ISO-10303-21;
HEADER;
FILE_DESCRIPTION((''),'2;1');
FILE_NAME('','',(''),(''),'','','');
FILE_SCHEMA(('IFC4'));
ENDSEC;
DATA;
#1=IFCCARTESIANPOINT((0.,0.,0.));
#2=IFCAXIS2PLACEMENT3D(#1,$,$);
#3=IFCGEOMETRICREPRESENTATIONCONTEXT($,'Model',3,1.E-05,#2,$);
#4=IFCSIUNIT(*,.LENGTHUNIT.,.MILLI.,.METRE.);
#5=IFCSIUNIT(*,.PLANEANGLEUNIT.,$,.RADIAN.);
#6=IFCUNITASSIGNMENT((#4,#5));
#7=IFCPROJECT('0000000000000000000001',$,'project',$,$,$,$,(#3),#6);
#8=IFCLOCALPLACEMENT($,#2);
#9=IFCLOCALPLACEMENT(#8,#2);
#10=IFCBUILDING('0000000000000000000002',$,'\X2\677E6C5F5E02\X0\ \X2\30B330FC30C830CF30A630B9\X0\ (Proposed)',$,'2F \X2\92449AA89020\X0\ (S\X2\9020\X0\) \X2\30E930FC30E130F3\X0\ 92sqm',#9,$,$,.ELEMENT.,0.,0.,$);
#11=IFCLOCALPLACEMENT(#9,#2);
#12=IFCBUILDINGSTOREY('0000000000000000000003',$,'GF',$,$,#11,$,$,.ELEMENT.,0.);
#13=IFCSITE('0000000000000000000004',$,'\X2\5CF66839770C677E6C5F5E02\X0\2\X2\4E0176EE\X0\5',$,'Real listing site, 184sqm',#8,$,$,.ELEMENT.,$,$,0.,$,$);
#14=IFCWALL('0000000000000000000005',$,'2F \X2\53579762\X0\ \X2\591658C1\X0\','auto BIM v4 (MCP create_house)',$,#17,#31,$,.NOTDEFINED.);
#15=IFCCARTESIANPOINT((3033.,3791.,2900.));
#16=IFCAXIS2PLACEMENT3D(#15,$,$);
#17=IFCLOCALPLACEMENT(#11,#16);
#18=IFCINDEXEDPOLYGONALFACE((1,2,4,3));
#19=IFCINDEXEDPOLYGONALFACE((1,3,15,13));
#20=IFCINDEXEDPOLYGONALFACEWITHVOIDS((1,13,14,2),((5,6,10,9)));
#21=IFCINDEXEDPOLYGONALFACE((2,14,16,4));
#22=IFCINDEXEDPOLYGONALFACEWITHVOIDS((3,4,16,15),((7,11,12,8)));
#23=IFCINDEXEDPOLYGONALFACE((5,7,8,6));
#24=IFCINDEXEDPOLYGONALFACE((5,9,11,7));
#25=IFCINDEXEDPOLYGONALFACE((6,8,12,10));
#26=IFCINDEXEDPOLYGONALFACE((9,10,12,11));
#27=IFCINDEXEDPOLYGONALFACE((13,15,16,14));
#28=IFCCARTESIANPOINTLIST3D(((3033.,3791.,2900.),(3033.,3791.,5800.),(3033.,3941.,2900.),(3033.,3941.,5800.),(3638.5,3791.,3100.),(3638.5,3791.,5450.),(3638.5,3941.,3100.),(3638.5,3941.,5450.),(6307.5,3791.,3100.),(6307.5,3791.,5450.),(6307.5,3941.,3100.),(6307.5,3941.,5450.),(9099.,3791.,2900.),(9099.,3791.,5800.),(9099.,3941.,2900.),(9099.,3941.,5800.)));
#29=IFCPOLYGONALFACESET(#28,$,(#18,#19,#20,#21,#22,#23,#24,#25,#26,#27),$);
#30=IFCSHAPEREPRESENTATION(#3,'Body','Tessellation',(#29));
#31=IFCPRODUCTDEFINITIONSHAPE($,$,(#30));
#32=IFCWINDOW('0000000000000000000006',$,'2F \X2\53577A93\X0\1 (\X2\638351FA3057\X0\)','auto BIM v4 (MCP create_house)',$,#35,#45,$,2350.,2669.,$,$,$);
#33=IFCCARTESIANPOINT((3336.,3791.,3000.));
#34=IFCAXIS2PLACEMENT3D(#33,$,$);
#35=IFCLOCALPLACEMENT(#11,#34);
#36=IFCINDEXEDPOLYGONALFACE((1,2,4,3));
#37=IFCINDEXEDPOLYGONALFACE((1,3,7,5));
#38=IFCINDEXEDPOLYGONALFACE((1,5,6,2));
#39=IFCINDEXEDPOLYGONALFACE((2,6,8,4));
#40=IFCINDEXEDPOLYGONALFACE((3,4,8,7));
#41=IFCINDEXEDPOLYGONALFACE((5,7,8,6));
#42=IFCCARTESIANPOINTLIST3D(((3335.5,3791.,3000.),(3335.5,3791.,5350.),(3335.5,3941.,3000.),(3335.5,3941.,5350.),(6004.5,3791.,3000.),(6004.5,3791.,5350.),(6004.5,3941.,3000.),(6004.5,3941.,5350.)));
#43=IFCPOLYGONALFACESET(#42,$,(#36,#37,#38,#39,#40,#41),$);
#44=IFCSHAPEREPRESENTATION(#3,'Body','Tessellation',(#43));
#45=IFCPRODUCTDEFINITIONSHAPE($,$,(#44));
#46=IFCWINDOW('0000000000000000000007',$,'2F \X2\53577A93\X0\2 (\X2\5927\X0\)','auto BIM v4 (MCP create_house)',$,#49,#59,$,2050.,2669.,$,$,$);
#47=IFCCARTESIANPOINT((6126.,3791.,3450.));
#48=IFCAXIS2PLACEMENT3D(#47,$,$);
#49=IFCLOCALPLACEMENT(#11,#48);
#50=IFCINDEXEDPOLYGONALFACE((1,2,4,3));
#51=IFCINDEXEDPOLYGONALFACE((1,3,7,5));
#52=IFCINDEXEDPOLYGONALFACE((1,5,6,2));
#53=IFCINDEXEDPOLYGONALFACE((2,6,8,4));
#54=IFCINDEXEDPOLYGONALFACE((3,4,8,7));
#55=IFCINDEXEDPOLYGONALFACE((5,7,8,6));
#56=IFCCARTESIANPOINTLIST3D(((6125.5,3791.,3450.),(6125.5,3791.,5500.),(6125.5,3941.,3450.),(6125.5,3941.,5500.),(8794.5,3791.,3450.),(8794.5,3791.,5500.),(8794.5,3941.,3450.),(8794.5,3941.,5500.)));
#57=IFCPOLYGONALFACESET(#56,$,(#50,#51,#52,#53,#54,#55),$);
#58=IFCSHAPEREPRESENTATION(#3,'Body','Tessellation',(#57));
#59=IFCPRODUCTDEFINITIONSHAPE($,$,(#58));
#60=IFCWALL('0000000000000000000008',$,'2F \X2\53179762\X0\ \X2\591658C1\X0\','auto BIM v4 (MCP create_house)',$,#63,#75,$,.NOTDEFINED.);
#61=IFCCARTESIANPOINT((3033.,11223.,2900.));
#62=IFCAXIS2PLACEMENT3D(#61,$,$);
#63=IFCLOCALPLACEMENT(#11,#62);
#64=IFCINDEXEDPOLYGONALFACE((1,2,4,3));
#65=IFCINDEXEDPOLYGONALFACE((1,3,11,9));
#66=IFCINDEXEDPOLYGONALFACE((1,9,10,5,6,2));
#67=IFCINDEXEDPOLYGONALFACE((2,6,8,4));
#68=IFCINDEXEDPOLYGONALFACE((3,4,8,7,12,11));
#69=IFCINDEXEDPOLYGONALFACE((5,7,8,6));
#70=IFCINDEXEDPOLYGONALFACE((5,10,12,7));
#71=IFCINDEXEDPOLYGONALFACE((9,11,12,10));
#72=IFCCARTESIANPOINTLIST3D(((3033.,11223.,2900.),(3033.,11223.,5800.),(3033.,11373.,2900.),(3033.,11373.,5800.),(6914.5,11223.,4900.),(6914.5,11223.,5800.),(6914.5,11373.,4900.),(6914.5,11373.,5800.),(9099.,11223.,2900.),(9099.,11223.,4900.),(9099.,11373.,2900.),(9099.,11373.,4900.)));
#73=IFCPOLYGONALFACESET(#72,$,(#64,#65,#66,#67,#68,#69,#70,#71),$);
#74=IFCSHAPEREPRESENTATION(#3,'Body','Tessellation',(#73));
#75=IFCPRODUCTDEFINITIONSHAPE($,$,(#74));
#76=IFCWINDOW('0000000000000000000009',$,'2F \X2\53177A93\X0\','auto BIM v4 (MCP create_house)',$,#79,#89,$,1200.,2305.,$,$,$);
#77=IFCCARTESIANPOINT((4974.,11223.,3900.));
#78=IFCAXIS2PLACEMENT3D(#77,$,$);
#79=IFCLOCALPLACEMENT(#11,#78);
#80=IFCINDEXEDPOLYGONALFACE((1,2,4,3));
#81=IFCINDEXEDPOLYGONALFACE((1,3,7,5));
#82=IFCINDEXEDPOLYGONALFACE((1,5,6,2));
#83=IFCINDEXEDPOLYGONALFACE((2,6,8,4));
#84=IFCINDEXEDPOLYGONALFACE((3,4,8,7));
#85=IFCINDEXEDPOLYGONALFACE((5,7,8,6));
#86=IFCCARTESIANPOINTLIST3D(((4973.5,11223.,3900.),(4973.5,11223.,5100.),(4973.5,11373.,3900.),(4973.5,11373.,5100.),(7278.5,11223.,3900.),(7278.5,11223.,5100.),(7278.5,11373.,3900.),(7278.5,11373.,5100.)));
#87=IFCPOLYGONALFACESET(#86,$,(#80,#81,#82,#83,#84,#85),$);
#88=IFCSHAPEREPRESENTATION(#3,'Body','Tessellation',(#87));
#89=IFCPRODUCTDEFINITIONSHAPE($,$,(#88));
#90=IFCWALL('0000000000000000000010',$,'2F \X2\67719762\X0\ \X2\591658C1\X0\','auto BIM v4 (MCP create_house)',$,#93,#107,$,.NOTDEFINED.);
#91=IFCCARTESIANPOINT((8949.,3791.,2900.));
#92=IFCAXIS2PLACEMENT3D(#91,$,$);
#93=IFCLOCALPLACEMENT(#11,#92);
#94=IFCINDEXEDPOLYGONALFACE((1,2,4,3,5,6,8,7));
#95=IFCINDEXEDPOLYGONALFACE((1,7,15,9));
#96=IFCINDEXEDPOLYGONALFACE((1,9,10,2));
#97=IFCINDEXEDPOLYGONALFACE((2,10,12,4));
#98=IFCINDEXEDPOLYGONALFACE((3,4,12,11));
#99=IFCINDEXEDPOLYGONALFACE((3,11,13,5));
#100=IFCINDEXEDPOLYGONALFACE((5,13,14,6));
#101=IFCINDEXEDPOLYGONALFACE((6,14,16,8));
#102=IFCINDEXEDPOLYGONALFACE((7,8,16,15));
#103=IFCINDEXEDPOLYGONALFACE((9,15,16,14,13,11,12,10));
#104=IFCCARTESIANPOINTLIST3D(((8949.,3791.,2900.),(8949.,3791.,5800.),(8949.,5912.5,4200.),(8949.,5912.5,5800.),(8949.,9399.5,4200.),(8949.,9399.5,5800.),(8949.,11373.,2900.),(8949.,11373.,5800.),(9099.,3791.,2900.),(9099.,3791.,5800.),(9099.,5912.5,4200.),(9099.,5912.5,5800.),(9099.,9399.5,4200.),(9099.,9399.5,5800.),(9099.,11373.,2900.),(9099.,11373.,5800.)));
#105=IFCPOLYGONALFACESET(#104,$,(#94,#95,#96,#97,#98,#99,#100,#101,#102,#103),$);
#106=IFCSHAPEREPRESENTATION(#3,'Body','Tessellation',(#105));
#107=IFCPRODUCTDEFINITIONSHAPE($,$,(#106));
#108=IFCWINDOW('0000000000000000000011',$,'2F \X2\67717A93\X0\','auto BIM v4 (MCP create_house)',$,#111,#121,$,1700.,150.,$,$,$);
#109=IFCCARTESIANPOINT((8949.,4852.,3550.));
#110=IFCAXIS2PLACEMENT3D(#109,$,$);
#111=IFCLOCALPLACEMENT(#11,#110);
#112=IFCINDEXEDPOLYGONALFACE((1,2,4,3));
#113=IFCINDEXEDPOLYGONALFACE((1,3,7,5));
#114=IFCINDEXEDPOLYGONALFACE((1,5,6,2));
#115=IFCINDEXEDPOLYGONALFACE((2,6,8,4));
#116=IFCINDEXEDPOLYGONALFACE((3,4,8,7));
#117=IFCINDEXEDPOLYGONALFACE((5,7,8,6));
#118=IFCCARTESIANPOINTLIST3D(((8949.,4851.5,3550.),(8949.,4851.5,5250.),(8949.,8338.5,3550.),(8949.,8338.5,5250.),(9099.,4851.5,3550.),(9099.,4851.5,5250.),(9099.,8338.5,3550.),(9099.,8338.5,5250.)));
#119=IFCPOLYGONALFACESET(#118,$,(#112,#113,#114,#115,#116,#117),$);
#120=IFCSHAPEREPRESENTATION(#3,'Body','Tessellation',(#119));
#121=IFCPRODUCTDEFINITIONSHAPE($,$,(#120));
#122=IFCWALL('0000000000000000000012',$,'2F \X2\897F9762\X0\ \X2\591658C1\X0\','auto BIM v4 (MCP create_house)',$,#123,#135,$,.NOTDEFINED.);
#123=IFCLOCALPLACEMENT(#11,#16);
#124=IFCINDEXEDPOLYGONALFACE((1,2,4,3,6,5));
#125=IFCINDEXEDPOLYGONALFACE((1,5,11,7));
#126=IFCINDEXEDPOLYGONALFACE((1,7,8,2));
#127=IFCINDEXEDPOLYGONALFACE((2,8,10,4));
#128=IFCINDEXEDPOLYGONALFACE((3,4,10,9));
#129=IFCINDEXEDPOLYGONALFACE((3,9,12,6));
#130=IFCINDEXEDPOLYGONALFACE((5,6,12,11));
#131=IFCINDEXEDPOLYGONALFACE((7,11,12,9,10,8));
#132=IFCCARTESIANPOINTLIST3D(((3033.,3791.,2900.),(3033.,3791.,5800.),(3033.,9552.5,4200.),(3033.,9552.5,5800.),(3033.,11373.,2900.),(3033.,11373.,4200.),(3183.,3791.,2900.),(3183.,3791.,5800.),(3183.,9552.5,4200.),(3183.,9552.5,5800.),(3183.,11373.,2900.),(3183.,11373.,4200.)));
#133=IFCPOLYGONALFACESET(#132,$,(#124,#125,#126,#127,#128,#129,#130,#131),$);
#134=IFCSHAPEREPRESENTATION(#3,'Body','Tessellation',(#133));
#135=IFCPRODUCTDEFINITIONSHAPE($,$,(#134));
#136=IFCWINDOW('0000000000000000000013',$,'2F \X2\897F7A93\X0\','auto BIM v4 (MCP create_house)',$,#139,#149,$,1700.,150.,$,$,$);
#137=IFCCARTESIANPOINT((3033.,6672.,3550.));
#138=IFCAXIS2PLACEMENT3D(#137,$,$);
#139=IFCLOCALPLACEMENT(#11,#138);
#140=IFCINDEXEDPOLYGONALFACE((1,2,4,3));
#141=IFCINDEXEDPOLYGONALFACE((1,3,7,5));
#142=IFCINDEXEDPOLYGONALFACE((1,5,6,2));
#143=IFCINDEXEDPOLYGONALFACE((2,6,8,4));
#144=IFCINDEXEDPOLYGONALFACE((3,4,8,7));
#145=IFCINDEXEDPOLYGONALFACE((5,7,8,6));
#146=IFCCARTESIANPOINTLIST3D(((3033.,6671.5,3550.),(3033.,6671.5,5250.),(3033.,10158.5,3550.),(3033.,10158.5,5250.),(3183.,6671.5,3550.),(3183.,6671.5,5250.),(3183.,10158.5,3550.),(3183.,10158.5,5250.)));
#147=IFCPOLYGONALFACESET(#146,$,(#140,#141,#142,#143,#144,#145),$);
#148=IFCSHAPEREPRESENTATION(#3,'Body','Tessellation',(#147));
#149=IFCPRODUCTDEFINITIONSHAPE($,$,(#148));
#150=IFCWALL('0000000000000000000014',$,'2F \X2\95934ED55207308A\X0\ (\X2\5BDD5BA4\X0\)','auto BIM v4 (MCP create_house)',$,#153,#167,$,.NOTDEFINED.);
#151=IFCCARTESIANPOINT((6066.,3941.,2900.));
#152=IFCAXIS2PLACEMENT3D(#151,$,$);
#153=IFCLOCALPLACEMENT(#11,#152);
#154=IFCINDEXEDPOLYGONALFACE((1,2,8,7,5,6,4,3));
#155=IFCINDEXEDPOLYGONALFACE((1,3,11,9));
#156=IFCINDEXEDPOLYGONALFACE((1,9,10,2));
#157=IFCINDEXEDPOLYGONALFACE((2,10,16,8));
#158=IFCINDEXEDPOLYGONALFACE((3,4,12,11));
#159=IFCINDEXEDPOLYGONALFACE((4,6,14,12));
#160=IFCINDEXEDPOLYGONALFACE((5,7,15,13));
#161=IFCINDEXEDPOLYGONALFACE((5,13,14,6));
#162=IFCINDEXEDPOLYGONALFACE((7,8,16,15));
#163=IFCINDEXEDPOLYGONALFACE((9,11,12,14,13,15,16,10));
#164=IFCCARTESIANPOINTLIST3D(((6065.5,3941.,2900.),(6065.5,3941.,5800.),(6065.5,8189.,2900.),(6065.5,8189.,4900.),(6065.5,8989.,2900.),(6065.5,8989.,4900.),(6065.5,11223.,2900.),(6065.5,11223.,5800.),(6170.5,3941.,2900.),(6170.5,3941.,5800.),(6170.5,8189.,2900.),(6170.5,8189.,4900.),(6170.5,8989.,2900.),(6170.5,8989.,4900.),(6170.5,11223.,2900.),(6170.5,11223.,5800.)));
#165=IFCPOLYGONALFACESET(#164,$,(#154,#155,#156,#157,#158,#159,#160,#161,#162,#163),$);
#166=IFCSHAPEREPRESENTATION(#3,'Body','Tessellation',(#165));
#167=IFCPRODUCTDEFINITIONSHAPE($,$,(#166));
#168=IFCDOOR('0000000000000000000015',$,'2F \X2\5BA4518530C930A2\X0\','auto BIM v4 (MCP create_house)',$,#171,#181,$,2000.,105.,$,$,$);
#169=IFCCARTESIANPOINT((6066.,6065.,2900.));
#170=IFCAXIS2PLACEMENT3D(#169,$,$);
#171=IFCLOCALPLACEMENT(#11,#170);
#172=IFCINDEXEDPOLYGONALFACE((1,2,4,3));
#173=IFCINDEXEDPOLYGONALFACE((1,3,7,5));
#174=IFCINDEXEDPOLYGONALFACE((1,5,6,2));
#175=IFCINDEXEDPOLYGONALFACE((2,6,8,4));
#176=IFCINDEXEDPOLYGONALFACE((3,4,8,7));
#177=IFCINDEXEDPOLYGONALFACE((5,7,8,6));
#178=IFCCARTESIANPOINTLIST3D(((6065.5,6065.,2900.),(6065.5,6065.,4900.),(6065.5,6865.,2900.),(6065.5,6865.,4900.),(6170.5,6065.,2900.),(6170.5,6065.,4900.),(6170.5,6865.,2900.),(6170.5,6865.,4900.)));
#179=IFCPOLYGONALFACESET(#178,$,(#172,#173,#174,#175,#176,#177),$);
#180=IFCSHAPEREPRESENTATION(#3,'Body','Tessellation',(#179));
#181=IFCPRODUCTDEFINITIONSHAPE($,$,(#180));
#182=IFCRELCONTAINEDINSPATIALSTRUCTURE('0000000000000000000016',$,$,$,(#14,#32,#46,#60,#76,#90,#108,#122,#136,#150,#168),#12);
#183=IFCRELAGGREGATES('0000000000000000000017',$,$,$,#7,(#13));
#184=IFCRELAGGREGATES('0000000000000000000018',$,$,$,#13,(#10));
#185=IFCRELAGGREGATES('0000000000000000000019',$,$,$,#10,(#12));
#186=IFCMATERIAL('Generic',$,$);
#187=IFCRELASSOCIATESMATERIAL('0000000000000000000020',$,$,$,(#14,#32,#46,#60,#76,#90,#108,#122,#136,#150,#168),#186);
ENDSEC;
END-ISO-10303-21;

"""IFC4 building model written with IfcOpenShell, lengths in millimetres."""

from ifc_helpers import new_model, si_unit, frame, frame_2d, origin, place, context, project, spatial, rectangle, extrude, material, element, fill, save


model = new_model("IFC4")

# Units and contexts
model_context = context("Model", 3, precision=1e-05, world=origin())
ifc_project = project(units=[si_unit("LENGTHUNIT", "METRE", prefix="MILLI"), si_unit("PLANEANGLEUNIT", "RADIAN")], contexts=[model_context])

# Site, building, storey
site_placement = place(None, origin())
site = spatial("IfcSite", under=ifc_project, at=site_placement, Name="島根県松江市2丁目5", ObjectType="Real listing site, 184sqm", CompositionType="ELEMENT", RefElevation=0.0)
building_placement = place(site_placement, origin())
building = spatial("IfcBuilding", under=site, at=building_placement, Name="松江市 コートハウス (Proposed)", ObjectType="2F 鉄骨造 (S造) ラーメン 92sqm", CompositionType="ELEMENT", ElevationOfRefHeight=0.0, ElevationOfTerrain=0.0)
storey_placement = place(building_placement, origin())
storey = spatial("IfcBuildingStorey", under=building, at=storey_placement, Name="GF", CompositionType="ELEMENT", Elevation=0.0)

# Shared definitions
ifc_material = material(Name="Generic")

# Wall, openings, windows
wall_1_placement = place(storey_placement, frame((3033.0, 3791.0, 2900.0)))
wall_1 = element("IfcWall", 1, at=wall_1_placement, inside=storey, material=ifc_material, Name="2F 南面 外壁", Description="auto BIM v4 (MCP create_house)", PredefinedType="NOTDEFINED", context=model_context, shape_type="SweptSolid", body=[
    extrude(rectangle(XDim=6066.0, YDim=150.0, at=frame_2d((3033.0, 75.0))), frame((3033.0, 3791.0, 2900.0)), (0.0, 0.0, 1.0), 2900.0),
])
opening_1_placement = place(storey_placement, frame((3336.0, 3791.0, 3000.0)))
opening_1 = element("IfcOpeningElement", 2, at=opening_1_placement, cuts=wall_1, PredefinedType="NOTDEFINED", context=model_context, shape_type="SweptSolid", body=[
    extrude(rectangle(XDim=2669.0, YDim=150.0, at=frame_2d((1334.0, 75.0))), frame((3336.0, 3791.0, 3000.0)), (0.0, 0.0, 1.0), 2350.0),
])
opening_2_placement = place(storey_placement, frame((6126.0, 3791.0, 3450.0)))
opening_2 = element("IfcOpeningElement", 3, at=opening_2_placement, cuts=wall_1, PredefinedType="NOTDEFINED", context=model_context, shape_type="SweptSolid", body=[
    extrude(rectangle(XDim=2669.0, YDim=150.0, at=frame_2d((1334.0, 75.0))), frame((6126.0, 3791.0, 3450.0)), (0.0, 0.0, 1.0), 2050.0),
])
window_1_placement = place(storey_placement, frame((3336.0, 3791.0, 3000.0)))
window_1 = element("IfcWindow", 4, at=window_1_placement, inside=storey, material=ifc_material, Name="2F 南窓1 (掃出し)", Description="auto BIM v4 (MCP create_house)", OverallHeight=2350.0, OverallWidth=2669.0, context=model_context, shape_type="SweptSolid", body=[
    extrude(rectangle(XDim=2669.0, YDim=150.0, at=frame_2d((1334.0, 75.0))), frame((3336.0, 3791.0, 3000.0)), (0.0, 0.0, 1.0), 2350.0),
])
fill(opening_1, window_1)
window_2_placement = place(storey_placement, frame((6126.0, 3791.0, 3450.0)))
window_2 = element("IfcWindow", 5, at=window_2_placement, inside=storey, material=ifc_material, Name="2F 南窓2 (大)", Description="auto BIM v4 (MCP create_house)", OverallHeight=2050.0, OverallWidth=2669.0, context=model_context, shape_type="SweptSolid", body=[
    extrude(rectangle(XDim=2669.0, YDim=150.0, at=frame_2d((1334.0, 75.0))), frame((6126.0, 3791.0, 3450.0)), (0.0, 0.0, 1.0), 2050.0),
])
fill(opening_2, window_2)

# Walls, openings, windows
wall_2_placement = place(storey_placement, frame((3033.0, 11223.0, 2900.0)))
wall_2 = element("IfcWall", 6, at=wall_2_placement, inside=storey, material=ifc_material, Name="2F 北面 外壁", Description="auto BIM v4 (MCP create_house)", PredefinedType="NOTDEFINED", context=model_context, shape_type="SweptSolid", body=[
    extrude(rectangle(XDim=6066.0, YDim=150.0, at=frame_2d((3033.0, 75.0))), frame((3033.0, 11223.0, 2900.0)), (0.0, 0.0, 1.0), 2900.0),
])
opening_3_placement = place(storey_placement, frame((4974.0, 11223.0, 3900.0)))
opening_3 = element("IfcOpeningElement", 7, at=opening_3_placement, cuts=wall_2, PredefinedType="NOTDEFINED", context=model_context, shape_type="SweptSolid", body=[
    extrude(rectangle(XDim=2305.0, YDim=150.0, at=frame_2d((1152.0, 75.0))), frame((4974.0, 11223.0, 3900.0)), (0.0, 0.0, 1.0), 1200.0),
])
window_3_placement = place(storey_placement, frame((4974.0, 11223.0, 3900.0)))
window_3 = element("IfcWindow", 8, at=window_3_placement, inside=storey, material=ifc_material, Name="2F 北窓", Description="auto BIM v4 (MCP create_house)", OverallHeight=1200.0, OverallWidth=2305.0, context=model_context, shape_type="SweptSolid", body=[
    extrude(rectangle(XDim=2305.0, YDim=150.0, at=frame_2d((1152.0, 75.0))), frame((4974.0, 11223.0, 3900.0)), (0.0, 0.0, 1.0), 1200.0),
])
fill(opening_3, window_3)
wall_3_placement = place(storey_placement, frame((8949.0, 3791.0, 2900.0)))
wall_3 = element("IfcWall", 9, at=wall_3_placement, inside=storey, material=ifc_material, Name="2F 東面 外壁", Description="auto BIM v4 (MCP create_house)", PredefinedType="NOTDEFINED", context=model_context, shape_type="SweptSolid", body=[
    extrude(rectangle(XDim=150.0, YDim=7582.0, at=frame_2d((75.0, 3791.0))), frame((8949.0, 3791.0, 2900.0)), (0.0, 0.0, 1.0), 2900.0),
])
opening_4_placement = place(storey_placement, frame((8949.0, 4852.0, 3550.0)))
opening_4 = element("IfcOpeningElement", 10, at=opening_4_placement, cuts=wall_3, PredefinedType="NOTDEFINED", context=model_context, shape_type="SweptSolid", body=[
    extrude(rectangle(XDim=150.0, YDim=3487.0, at=frame_2d((75.0, 1743.0))), frame((8949.0, 4852.0, 3550.0)), (0.0, 0.0, 1.0), 1700.0),
])
window_4_placement = place(storey_placement, frame((8949.0, 4852.0, 3550.0)))
window_4 = element("IfcWindow", 11, at=window_4_placement, inside=storey, material=ifc_material, Name="2F 東窓", Description="auto BIM v4 (MCP create_house)", OverallHeight=1700.0, OverallWidth=150.0, context=model_context, shape_type="SweptSolid", body=[
    extrude(rectangle(XDim=150.0, YDim=3487.0, at=frame_2d((75.0, 1743.0))), frame((8949.0, 4852.0, 3550.0)), (0.0, 0.0, 1.0), 1700.0),
])
fill(opening_4, window_4)
wall_4_placement = place(storey_placement, frame((3033.0, 3791.0, 2900.0)))
wall_4 = element("IfcWall", 12, at=wall_4_placement, inside=storey, material=ifc_material, Name="2F 西面 外壁", Description="auto BIM v4 (MCP create_house)", PredefinedType="NOTDEFINED", context=model_context, shape_type="SweptSolid", body=[
    extrude(rectangle(XDim=150.0, YDim=7582.0, at=frame_2d((75.0, 3791.0))), frame((3033.0, 3791.0, 2900.0)), (0.0, 0.0, 1.0), 2900.0),
])
opening_5_placement = place(storey_placement, frame((3033.0, 6672.0, 3550.0)))
opening_5 = element("IfcOpeningElement", 13, at=opening_5_placement, cuts=wall_4, PredefinedType="NOTDEFINED", context=model_context, shape_type="SweptSolid", body=[
    extrude(rectangle(XDim=150.0, YDim=3487.0, at=frame_2d((75.0, 1743.0))), frame((3033.0, 6672.0, 3550.0)), (0.0, 0.0, 1.0), 1700.0),
])
window_5_placement = place(storey_placement, frame((3033.0, 6672.0, 3550.0)))
window_5 = element("IfcWindow", 14, at=window_5_placement, inside=storey, material=ifc_material, Name="2F 西窓", Description="auto BIM v4 (MCP create_house)", OverallHeight=1700.0, OverallWidth=150.0, context=model_context, shape_type="SweptSolid", body=[
    extrude(rectangle(XDim=150.0, YDim=3487.0, at=frame_2d((75.0, 1743.0))), frame((3033.0, 6672.0, 3550.0)), (0.0, 0.0, 1.0), 1700.0),
])
fill(opening_5, window_5)

# Wall, opening, door
wall_5_placement = place(storey_placement, frame((6066.0, 3941.0, 2900.0)))
wall_5 = element("IfcWall", 15, at=wall_5_placement, inside=storey, material=ifc_material, Name="2F 間仕切り (寝室)", Description="auto BIM v4 (MCP create_house)", PredefinedType="NOTDEFINED", context=model_context, shape_type="SweptSolid", body=[
    extrude(rectangle(XDim=105.0, YDim=7282.0, at=frame_2d((52.0, 3641.0))), frame((6066.0, 3941.0, 2900.0)), (0.0, 0.0, 1.0), 2900.0),
])
opening_6_placement = place(storey_placement, frame((6066.0, 6065.0, 2900.0)))
opening_6 = element("IfcOpeningElement", 16, at=opening_6_placement, cuts=wall_5, PredefinedType="NOTDEFINED", context=model_context, shape_type="SweptSolid", body=[
    extrude(rectangle(XDim=105.0, YDim=800.0, at=frame_2d((52.0, 400.0))), frame((6066.0, 6065.0, 2900.0)), (0.0, 0.0, 1.0), 2000.0),
])
door_1_placement = place(storey_placement, frame((6066.0, 6065.0, 2900.0)))
door_1 = element("IfcDoor", 17, at=door_1_placement, inside=storey, material=ifc_material, Name="2F 室内ドア", Description="auto BIM v4 (MCP create_house)", OverallHeight=2000.0, OverallWidth=105.0, context=model_context, shape_type="SweptSolid", body=[
    extrude(rectangle(XDim=105.0, YDim=800.0, at=frame_2d((52.0, 400.0))), frame((6066.0, 6065.0, 2900.0)), (0.0, 0.0, 1.0), 2000.0),
])
fill(opening_6, door_1)

save(model, "model.ifc")
